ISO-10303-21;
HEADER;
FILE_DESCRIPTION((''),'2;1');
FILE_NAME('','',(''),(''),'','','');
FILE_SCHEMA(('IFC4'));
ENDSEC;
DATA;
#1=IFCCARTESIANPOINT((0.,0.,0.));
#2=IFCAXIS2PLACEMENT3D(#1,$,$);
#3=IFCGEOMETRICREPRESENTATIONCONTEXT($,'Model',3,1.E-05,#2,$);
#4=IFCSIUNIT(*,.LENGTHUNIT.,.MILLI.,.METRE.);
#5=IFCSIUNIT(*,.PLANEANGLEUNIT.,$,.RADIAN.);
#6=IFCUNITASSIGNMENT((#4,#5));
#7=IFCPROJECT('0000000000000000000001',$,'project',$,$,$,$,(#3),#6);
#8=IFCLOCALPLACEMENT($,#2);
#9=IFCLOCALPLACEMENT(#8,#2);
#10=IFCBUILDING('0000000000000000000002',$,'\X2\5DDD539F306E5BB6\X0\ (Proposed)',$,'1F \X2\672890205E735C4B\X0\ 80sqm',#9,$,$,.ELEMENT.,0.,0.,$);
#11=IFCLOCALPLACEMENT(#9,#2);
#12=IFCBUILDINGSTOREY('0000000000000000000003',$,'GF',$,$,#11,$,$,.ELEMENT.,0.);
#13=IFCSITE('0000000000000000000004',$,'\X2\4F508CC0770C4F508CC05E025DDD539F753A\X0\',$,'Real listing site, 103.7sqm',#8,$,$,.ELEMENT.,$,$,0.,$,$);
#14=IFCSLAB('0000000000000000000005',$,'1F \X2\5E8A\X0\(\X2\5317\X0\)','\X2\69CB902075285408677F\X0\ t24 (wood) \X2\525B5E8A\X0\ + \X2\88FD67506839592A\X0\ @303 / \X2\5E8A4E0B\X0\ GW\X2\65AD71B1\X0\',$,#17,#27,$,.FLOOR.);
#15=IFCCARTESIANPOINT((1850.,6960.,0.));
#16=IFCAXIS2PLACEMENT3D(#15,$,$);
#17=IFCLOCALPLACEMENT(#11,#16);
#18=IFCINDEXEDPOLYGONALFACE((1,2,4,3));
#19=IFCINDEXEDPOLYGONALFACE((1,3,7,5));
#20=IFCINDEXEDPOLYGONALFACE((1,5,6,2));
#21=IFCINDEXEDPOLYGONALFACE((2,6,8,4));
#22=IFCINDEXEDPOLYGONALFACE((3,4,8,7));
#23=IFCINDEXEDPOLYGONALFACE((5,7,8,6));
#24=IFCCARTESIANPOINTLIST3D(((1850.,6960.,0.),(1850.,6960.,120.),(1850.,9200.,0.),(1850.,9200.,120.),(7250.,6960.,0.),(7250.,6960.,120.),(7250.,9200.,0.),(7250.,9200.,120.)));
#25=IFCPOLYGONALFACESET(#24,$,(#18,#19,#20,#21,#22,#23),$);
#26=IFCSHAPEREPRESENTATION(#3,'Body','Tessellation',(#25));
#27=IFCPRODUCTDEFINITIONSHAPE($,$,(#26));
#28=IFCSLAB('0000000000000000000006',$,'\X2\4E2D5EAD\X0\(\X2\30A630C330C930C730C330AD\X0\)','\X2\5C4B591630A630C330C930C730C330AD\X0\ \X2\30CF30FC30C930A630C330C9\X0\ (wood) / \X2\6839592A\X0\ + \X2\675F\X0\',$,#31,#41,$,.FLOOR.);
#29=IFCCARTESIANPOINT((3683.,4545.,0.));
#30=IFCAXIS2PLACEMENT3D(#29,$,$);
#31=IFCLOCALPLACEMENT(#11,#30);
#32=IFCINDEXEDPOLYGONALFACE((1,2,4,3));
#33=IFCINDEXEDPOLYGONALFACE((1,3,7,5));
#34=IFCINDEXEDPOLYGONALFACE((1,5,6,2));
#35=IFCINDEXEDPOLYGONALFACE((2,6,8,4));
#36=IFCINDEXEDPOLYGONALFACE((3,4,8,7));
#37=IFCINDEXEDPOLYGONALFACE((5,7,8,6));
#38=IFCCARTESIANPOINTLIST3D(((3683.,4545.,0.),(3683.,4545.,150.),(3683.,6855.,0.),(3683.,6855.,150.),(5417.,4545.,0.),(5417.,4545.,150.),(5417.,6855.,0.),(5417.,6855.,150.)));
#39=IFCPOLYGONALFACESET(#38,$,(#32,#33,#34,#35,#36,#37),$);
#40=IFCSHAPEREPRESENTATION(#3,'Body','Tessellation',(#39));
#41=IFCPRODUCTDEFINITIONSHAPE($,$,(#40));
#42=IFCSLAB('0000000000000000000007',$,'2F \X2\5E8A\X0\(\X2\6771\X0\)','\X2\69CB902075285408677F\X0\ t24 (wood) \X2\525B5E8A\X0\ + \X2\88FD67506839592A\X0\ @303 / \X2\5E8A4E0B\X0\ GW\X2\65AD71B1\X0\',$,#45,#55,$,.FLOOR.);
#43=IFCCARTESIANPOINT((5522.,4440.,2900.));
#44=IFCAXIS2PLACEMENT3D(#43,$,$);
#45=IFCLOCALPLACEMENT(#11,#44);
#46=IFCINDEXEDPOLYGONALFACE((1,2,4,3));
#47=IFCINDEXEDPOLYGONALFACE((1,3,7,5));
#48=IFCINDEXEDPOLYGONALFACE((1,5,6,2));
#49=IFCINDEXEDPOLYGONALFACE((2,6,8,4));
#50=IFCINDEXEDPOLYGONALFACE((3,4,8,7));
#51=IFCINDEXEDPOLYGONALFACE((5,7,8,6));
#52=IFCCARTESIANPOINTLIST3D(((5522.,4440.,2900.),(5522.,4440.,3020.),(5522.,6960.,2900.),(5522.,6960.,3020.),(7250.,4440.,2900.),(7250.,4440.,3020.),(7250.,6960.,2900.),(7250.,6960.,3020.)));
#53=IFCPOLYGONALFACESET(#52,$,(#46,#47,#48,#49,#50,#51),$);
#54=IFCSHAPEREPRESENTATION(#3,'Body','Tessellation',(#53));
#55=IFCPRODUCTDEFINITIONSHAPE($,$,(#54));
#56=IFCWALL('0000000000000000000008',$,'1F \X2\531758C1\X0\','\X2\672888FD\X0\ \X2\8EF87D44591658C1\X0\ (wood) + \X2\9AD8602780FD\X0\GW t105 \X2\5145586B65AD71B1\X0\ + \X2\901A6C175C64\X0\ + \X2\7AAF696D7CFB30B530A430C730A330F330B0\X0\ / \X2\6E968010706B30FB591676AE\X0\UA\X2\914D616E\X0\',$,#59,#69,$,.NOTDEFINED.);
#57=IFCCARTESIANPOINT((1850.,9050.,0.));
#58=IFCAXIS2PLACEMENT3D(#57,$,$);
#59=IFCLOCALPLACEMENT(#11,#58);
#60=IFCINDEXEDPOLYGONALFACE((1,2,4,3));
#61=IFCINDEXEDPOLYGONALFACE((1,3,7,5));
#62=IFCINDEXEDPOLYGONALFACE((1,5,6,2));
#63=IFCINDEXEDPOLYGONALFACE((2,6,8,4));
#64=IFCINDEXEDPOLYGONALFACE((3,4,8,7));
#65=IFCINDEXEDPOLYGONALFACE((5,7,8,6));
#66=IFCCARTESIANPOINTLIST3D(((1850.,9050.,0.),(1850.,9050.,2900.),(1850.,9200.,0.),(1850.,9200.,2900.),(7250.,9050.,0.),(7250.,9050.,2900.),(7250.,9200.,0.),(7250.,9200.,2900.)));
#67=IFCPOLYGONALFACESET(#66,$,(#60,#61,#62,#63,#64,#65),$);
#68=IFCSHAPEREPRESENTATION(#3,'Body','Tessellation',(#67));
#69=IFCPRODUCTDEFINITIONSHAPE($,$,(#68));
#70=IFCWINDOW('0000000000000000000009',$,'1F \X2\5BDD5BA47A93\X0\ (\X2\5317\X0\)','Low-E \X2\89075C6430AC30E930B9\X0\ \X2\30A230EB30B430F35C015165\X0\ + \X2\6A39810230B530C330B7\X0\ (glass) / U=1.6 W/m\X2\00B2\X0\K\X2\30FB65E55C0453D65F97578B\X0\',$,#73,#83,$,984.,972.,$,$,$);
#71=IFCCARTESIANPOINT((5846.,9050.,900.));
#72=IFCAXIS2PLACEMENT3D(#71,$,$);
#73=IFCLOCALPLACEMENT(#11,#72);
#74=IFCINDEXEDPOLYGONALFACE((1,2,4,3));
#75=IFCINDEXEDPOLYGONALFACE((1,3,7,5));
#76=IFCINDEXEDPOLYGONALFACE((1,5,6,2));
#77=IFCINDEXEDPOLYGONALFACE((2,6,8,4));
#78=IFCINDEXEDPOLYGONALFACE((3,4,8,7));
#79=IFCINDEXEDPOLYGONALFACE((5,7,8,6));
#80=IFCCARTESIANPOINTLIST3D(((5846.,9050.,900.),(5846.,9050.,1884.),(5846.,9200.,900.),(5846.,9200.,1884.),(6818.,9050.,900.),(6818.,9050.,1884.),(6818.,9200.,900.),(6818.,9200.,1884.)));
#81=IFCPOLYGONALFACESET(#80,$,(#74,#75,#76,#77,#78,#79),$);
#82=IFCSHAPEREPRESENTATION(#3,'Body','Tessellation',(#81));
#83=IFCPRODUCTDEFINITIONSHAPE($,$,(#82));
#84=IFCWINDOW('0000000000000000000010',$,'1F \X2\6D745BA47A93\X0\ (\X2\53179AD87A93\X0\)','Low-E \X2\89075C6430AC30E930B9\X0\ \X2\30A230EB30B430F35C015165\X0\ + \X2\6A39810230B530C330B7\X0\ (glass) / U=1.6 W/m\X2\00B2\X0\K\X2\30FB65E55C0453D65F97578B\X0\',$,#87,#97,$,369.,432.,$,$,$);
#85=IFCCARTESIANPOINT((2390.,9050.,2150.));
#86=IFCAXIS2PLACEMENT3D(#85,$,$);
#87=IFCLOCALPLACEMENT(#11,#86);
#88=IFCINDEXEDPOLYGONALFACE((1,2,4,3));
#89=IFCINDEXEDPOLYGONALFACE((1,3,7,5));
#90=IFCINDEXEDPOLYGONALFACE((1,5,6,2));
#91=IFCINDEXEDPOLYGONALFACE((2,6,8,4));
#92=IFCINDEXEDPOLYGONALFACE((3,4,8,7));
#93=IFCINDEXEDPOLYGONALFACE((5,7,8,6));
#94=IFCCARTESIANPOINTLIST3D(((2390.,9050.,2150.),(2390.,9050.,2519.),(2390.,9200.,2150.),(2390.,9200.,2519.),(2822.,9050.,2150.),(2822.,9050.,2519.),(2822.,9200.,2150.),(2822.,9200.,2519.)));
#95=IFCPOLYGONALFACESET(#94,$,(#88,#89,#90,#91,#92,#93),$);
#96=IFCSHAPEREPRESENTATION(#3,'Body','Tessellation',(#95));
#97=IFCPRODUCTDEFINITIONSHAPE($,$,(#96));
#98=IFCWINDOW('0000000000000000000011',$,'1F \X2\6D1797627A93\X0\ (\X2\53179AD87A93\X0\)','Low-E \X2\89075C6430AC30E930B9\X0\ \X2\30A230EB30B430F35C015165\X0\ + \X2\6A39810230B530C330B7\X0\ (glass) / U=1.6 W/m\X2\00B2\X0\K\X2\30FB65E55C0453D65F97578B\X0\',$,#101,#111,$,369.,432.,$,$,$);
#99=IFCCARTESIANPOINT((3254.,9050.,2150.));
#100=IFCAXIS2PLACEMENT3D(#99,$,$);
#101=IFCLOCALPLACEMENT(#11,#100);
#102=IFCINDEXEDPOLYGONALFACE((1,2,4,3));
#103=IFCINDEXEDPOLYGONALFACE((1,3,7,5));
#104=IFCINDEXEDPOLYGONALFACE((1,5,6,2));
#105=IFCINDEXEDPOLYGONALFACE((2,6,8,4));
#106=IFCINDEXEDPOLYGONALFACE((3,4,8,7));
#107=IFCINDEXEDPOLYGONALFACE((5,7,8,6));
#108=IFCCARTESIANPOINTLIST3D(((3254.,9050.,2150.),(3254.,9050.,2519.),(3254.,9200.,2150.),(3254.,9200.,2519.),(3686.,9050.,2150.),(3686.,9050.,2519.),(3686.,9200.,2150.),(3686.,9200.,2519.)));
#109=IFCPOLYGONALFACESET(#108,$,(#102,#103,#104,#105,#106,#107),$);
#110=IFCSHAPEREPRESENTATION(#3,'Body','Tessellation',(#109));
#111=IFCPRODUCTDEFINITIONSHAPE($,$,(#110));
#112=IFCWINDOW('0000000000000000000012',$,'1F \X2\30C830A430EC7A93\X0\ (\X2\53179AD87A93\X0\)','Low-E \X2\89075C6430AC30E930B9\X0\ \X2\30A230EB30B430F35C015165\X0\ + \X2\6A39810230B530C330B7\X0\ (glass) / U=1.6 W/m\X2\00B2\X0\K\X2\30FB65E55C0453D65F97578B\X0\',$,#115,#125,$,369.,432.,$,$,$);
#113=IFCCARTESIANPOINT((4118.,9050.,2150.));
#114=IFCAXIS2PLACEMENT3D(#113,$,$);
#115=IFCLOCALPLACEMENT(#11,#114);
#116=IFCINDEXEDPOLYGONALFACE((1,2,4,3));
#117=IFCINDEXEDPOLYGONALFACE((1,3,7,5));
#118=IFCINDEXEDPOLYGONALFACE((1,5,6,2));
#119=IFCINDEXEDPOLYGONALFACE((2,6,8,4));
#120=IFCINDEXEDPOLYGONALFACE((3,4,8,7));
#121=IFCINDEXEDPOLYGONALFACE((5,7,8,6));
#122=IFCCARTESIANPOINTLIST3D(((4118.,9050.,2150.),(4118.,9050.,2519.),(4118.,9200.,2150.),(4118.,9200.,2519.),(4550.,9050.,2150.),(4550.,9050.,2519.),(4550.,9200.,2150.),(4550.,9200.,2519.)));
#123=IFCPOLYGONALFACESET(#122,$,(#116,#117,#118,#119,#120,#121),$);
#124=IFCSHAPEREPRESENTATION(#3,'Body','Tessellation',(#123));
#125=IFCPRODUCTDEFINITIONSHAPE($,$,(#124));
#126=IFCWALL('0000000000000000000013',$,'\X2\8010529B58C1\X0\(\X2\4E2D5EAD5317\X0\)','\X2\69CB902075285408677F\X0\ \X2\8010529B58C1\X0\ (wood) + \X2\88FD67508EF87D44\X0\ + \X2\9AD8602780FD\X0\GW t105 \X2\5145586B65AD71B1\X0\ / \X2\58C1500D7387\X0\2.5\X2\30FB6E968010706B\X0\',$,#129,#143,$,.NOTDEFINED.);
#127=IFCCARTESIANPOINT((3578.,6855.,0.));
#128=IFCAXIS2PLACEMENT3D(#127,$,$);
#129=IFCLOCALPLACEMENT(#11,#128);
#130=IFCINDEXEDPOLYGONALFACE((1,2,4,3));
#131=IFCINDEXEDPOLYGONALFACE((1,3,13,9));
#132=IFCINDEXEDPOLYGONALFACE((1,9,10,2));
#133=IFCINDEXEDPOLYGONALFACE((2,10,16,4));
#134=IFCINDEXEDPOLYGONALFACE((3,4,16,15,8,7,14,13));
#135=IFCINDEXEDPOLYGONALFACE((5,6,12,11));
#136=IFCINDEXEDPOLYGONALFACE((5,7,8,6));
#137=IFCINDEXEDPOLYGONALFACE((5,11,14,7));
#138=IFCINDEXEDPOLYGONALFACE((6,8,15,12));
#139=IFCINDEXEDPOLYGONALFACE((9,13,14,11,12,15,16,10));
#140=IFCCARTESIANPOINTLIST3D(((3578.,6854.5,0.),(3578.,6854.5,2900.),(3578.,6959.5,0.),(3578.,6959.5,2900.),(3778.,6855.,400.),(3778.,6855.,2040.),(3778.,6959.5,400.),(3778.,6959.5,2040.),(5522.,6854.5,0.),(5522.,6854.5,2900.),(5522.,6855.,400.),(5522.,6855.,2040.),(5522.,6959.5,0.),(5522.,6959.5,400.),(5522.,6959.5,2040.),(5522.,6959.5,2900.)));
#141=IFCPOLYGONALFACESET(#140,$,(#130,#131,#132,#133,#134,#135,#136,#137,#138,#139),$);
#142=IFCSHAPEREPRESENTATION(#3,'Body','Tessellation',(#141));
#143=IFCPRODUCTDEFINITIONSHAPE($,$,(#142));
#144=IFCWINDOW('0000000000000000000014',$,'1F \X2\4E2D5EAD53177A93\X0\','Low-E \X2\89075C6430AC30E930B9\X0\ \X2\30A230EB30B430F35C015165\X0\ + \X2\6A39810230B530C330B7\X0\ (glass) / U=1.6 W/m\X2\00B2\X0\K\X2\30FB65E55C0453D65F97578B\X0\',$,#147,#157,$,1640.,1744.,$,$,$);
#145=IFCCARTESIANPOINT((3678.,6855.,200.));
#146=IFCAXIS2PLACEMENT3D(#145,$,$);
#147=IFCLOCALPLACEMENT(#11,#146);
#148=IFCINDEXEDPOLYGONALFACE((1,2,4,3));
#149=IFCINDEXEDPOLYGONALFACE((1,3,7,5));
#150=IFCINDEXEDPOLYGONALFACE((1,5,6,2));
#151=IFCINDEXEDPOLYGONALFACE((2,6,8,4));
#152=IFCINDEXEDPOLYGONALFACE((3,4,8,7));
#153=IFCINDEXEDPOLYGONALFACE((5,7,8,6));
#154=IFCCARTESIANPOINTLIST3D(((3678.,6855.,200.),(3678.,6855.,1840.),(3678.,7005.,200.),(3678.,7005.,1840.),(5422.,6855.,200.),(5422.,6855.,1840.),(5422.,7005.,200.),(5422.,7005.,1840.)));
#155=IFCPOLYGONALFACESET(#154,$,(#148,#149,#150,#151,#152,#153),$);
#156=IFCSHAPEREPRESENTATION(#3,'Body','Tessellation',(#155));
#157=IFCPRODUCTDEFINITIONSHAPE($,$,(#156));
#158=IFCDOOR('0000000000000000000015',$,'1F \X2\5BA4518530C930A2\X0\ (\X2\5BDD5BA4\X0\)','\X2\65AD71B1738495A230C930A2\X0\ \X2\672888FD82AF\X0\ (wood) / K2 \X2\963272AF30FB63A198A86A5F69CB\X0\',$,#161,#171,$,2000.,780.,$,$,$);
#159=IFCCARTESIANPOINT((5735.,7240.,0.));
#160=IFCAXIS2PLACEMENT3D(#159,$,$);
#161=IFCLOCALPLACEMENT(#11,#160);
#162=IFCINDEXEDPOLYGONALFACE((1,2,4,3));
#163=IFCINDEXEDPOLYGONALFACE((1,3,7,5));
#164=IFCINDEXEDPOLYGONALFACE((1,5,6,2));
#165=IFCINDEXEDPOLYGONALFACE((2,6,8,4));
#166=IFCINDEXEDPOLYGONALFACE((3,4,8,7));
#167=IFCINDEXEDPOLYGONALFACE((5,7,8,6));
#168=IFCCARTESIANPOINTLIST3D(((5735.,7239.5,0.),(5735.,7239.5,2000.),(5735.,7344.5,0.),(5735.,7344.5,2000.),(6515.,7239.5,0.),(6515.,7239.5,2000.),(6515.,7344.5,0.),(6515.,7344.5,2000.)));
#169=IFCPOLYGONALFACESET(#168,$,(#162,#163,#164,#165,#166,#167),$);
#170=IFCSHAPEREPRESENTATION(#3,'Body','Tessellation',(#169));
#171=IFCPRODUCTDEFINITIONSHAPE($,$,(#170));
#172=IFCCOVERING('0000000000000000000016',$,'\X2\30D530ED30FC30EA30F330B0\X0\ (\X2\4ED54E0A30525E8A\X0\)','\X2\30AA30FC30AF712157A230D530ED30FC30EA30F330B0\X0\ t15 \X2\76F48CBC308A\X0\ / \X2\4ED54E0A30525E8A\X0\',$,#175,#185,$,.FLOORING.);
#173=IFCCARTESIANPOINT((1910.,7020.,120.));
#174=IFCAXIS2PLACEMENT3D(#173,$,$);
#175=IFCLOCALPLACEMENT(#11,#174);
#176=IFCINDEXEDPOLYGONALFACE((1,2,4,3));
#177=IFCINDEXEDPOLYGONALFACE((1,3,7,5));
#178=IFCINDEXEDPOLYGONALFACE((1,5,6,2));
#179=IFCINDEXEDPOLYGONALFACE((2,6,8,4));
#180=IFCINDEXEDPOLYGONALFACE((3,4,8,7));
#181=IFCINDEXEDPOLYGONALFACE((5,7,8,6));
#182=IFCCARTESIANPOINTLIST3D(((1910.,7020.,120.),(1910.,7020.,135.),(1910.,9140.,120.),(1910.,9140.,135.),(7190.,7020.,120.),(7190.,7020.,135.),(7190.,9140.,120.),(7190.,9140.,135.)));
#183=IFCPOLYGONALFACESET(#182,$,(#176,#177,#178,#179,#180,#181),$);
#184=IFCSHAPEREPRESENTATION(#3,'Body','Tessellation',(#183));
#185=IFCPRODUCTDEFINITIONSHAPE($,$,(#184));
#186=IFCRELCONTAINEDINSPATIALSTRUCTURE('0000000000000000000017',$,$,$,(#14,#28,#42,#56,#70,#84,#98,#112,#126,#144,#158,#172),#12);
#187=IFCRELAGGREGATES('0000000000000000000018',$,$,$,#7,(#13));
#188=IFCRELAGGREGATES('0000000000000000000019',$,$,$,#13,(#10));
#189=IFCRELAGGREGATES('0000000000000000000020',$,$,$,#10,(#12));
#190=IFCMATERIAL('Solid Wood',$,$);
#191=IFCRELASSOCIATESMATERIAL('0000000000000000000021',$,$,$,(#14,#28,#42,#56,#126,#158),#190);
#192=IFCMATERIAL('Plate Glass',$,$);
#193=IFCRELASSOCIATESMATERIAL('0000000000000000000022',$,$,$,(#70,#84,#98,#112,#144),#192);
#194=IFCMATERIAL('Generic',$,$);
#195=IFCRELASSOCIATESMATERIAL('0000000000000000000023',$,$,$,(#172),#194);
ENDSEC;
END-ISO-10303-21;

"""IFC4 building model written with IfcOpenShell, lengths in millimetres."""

from ifc_helpers import new_model, si_unit, frame, frame_2d, origin, place, context, project, spatial, rectangle, extrude, material, element, fill, save


model = new_model("IFC4")

# Units and contexts
model_context = context("Model", 3, precision=1e-05, world=origin())
ifc_project = project(units=[si_unit("LENGTHUNIT", "METRE", prefix="MILLI"), si_unit("PLANEANGLEUNIT", "RADIAN")], contexts=[model_context])

# Site, building, storey
site_placement = place(None, origin())
site = spatial("IfcSite", under=ifc_project, at=site_placement, Name="佐賀県佐賀市川原町", ObjectType="Real listing site, 103.7sqm", CompositionType="ELEMENT", RefElevation=0.0)
building_placement = place(site_placement, origin())
building = spatial("IfcBuilding", under=site, at=building_placement, Name="川原の家 (Proposed)", ObjectType="1F 木造平屋 80sqm", CompositionType="ELEMENT", ElevationOfRefHeight=0.0, ElevationOfTerrain=0.0)
storey_placement = place(building_placement, origin())
storey = spatial("IfcBuildingStorey", under=building, at=storey_placement, Name="GF", CompositionType="ELEMENT", Elevation=0.0)

# Slabs
ifc_material_1 = material(Name="Solid Wood")
slab_1_placement = place(storey_placement, frame((1850.0, 6960.0, 0.0)))
element("IfcSlab", 1, at=slab_1_placement, inside=storey, material=ifc_material_1, Name="1F 床(北)", Description="構造用合板 t24 (wood) 剛床 + 製材根太 @303 / 床下 GW断熱", PredefinedType="FLOOR", context=model_context, shape_type="SweptSolid", body=[
    extrude(rectangle(XDim=5400.0, YDim=2240.0, at=frame_2d((2700.0, 1120.0))), frame((1850.0, 6960.0, 0.0)), (0.0, 0.0, 1.0), 120.0),
])
slab_2_placement = place(storey_placement, frame((3683.0, 4545.0, 0.0)))
element("IfcSlab", 2, at=slab_2_placement, inside=storey, material=ifc_material_1, Name="中庭(ウッドデッキ)", Description="屋外ウッドデッキ ハードウッド (wood) / 根太 + 束", PredefinedType="FLOOR", context=model_context, shape_type="SweptSolid", body=[
    extrude(rectangle(XDim=1734.0, YDim=2310.0, at=frame_2d((867.0, 1155.0))), frame((3683.0, 4545.0, 0.0)), (0.0, 0.0, 1.0), 150.0),
])
slab_3_placement = place(storey_placement, frame((5522.0, 4440.0, 2900.0)))
element("IfcSlab", 3, at=slab_3_placement, inside=storey, material=ifc_material_1, Name="2F 床(東)", Description="構造用合板 t24 (wood) 剛床 + 製材根太 @303 / 床下 GW断熱", PredefinedType="FLOOR", context=model_context, shape_type="SweptSolid", body=[
    extrude(rectangle(XDim=1728.0, YDim=2520.0, at=frame_2d((864.0, 1260.0))), frame((5522.0, 4440.0, 2900.0)), (0.0, 0.0, 1.0), 120.0),
])

# Wall, openings, windows
wall_1_placement = place(storey_placement, frame((1850.0, 9050.0, 0.0)))
wall_1 = element("IfcWall", 4, at=wall_1_placement, inside=storey, material=ifc_material_1, Name="1F 北壁", Description="木製 軸組外壁 (wood) + 高性能GW t105 充填断熱 + 通気層 + 窯業系サイディング / 準耐火・外皮UA配慮", PredefinedType="NOTDEFINED", context=model_context, shape_type="SweptSolid", body=[
    extrude(rectangle(XDim=5400.0, YDim=150.0, at=frame_2d((2700.0, 75.0))), frame((1850.0, 9050.0, 0.0)), (0.0, 0.0, 1.0), 2900.0),
])
opening_1_placement = place(storey_placement, frame((5846.0, 9050.0, 900.0)))
opening_1 = element("IfcOpeningElement", 5, at=opening_1_placement, cuts=wall_1, PredefinedType="NOTDEFINED", context=model_context, shape_type="SweptSolid", body=[
    extrude(rectangle(XDim=972.0, YDim=150.0, at=frame_2d((486.0, 75.0))), frame((5846.0, 9050.0, 900.0)), (0.0, 0.0, 1.0), 984.0),
])
opening_2_placement = place(storey_placement, frame((2390.0, 9050.0, 2150.0)))
opening_2 = element("IfcOpeningElement", 6, at=opening_2_placement, cuts=wall_1, PredefinedType="NOTDEFINED", context=model_context, shape_type="SweptSolid", body=[
    extrude(rectangle(XDim=432.0, YDim=150.0, at=frame_2d((216.0, 75.0))), frame((2390.0, 9050.0, 2150.0)), (0.0, 0.0, 1.0), 369.0),
])
opening_3_placement = place(storey_placement, frame((3254.0, 9050.0, 2150.0)))
opening_3 = element("IfcOpeningElement", 7, at=opening_3_placement, cuts=wall_1, PredefinedType="NOTDEFINED", context=model_context, shape_type="SweptSolid", body=[
    extrude(rectangle(XDim=432.0, YDim=150.0, at=frame_2d((216.0, 75.0))), frame((3254.0, 9050.0, 2150.0)), (0.0, 0.0, 1.0), 369.0),
])
opening_4_placement = place(storey_placement, frame((4118.0, 9050.0, 2150.0)))
opening_4 = element("IfcOpeningElement", 8, at=opening_4_placement, cuts=wall_1, PredefinedType="NOTDEFINED", context=model_context, shape_type="SweptSolid", body=[
    extrude(rectangle(XDim=432.0, YDim=150.0, at=frame_2d((216.0, 75.0))), frame((4118.0, 9050.0, 2150.0)), (0.0, 0.0, 1.0), 369.0),
])
ifc_material_2 = material(Name="Plate Glass")
window_1_placement = place(storey_placement, frame((5846.0, 9050.0, 900.0)))
window_1 = element("IfcWindow", 9, at=window_1_placement, inside=storey, material=ifc_material_2, Name="1F 寝室窓 (北)", Description="Low-E 複層ガラス アルゴン封入 + 樹脂サッシ (glass) / U=1.6 W/m²K・日射取得型", OverallHeight=984.0, OverallWidth=972.0, context=model_context, shape_type="SweptSolid", body=[
    extrude(rectangle(XDim=972.0, YDim=150.0, at=frame_2d((486.0, 75.0))), frame((5846.0, 9050.0, 900.0)), (0.0, 0.0, 1.0), 984.0),
])
fill(opening_1, window_1)
window_2_placement = place(storey_placement, frame((2390.0, 9050.0, 2150.0)))
window_2 = element("IfcWindow", 10, at=window_2_placement, inside=storey, material=ifc_material_2, Name="1F 浴室窓 (北高窓)", Description="Low-E 複層ガラス アルゴン封入 + 樹脂サッシ (glass) / U=1.6 W/m²K・日射取得型", OverallHeight=369.0, OverallWidth=432.0, context=model_context, shape_type="SweptSolid", body=[
    extrude(rectangle(XDim=432.0, YDim=150.0, at=frame_2d((216.0, 75.0))), frame((2390.0, 9050.0, 2150.0)), (0.0, 0.0, 1.0), 369.0),
])
fill(opening_2, window_2)
window_3_placement = place(storey_placement, frame((3254.0, 9050.0, 2150.0)))
window_3 = element("IfcWindow", 11, at=window_3_placement, inside=storey, material=ifc_material_2, Name="1F 洗面窓 (北高窓)", Description="Low-E 複層ガラス アルゴン封入 + 樹脂サッシ (glass) / U=1.6 W/m²K・日射取得型", OverallHeight=369.0, OverallWidth=432.0, context=model_context, shape_type="SweptSolid", body=[
    extrude(rectangle(XDim=432.0, YDim=150.0, at=frame_2d((216.0, 75.0))), frame((3254.0, 9050.0, 2150.0)), (0.0, 0.0, 1.0), 369.0),
])
fill(opening_3, window_3)
window_4_placement = place(storey_placement, frame((4118.0, 9050.0, 2150.0)))
window_4 = element("IfcWindow", 12, at=window_4_placement, inside=storey, material=ifc_material_2, Name="1F トイレ窓 (北高窓)", Description="Low-E 複層ガラス アルゴン封入 + 樹脂サッシ (glass) / U=1.6 W/m²K・日射取得型", OverallHeight=369.0, OverallWidth=432.0, context=model_context, shape_type="SweptSolid", body=[
    extrude(rectangle(XDim=432.0, YDim=150.0, at=frame_2d((216.0, 75.0))), frame((4118.0, 9050.0, 2150.0)), (0.0, 0.0, 1.0), 369.0),
])
fill(opening_4, window_4)

# Wall, opening, window
wall_2_placement = place(storey_placement, frame((3578.0, 6855.0, 0.0)))
wall_2 = element("IfcWall", 13, at=wall_2_placement, inside=storey, material=ifc_material_1, Name="耐力壁(中庭北)", Description="構造用合板 耐力壁 (wood) + 製材軸組 + 高性能GW t105 充填断熱 / 壁倍率2.5・準耐火", PredefinedType="NOTDEFINED", context=model_context, shape_type="SweptSolid", body=[
    extrude(rectangle(XDim=1944.0, YDim=105.0, at=frame_2d((972.0, 52.0))), frame((3578.0, 6855.0, 0.0)), (0.0, 0.0, 1.0), 2900.0),
])
opening_5_placement = place(storey_placement, frame((3678.0, 6855.0, 200.0)))
opening_5 = element("IfcOpeningElement", 14, at=opening_5_placement, cuts=wall_2, PredefinedType="NOTDEFINED", context=model_context, shape_type="SweptSolid", body=[
    extrude(rectangle(XDim=1744.0, YDim=150.0, at=frame_2d((872.0, 75.0))), frame((3678.0, 6855.0, 200.0)), (0.0, 0.0, 1.0), 1640.0),
])
window_5_placement = place(storey_placement, frame((3678.0, 6855.0, 200.0)))
window_5 = element("IfcWindow", 15, at=window_5_placement, inside=storey, material=ifc_material_2, Name="1F 中庭北窓", Description="Low-E 複層ガラス アルゴン封入 + 樹脂サッシ (glass) / U=1.6 W/m²K・日射取得型", OverallHeight=1640.0, OverallWidth=1744.0, context=model_context, shape_type="SweptSolid", body=[
    extrude(rectangle(XDim=1744.0, YDim=150.0, at=frame_2d((872.0, 75.0))), frame((3678.0, 6855.0, 200.0)), (0.0, 0.0, 1.0), 1640.0),
])
fill(opening_5, window_5)

# Door
door_1_placement = place(storey_placement, frame((5735.0, 7240.0, 0.0)))
element("IfcDoor", 16, at=door_1_placement, inside=storey, material=ifc_material_1, Name="1F 室内ドア (寝室)", Description="断熱玄関ドア 木製芯 (wood) / K2 防犯・採風機構", OverallHeight=2000.0, OverallWidth=780.0, context=model_context, shape_type="SweptSolid", body=[
    extrude(rectangle(XDim=780.0, YDim=105.0, at=frame_2d((390.0, 52.0))), frame((5735.0, 7240.0, 0.0)), (0.0, 0.0, 1.0), 2000.0),
])

# Covering
ifc_material_3 = material(Name="Generic")
covering_1_placement = place(storey_placement, frame((1910.0, 7020.0, 120.0)))
element("IfcCovering", 17, at=covering_1_placement, inside=storey, material=ifc_material_3, Name="フローリング (仕上げ床)", Description="オーク無垢フローリング t15 直貼り / 仕上げ床", PredefinedType="FLOORING", context=model_context, shape_type="SweptSolid", body=[
    extrude(rectangle(XDim=5280.0, YDim=2120.0, at=frame_2d((2640.0, 1060.0))), frame((1910.0, 7020.0, 120.0)), (0.0, 0.0, 1.0), 15.0),
])

save(model, "model.ifc")
